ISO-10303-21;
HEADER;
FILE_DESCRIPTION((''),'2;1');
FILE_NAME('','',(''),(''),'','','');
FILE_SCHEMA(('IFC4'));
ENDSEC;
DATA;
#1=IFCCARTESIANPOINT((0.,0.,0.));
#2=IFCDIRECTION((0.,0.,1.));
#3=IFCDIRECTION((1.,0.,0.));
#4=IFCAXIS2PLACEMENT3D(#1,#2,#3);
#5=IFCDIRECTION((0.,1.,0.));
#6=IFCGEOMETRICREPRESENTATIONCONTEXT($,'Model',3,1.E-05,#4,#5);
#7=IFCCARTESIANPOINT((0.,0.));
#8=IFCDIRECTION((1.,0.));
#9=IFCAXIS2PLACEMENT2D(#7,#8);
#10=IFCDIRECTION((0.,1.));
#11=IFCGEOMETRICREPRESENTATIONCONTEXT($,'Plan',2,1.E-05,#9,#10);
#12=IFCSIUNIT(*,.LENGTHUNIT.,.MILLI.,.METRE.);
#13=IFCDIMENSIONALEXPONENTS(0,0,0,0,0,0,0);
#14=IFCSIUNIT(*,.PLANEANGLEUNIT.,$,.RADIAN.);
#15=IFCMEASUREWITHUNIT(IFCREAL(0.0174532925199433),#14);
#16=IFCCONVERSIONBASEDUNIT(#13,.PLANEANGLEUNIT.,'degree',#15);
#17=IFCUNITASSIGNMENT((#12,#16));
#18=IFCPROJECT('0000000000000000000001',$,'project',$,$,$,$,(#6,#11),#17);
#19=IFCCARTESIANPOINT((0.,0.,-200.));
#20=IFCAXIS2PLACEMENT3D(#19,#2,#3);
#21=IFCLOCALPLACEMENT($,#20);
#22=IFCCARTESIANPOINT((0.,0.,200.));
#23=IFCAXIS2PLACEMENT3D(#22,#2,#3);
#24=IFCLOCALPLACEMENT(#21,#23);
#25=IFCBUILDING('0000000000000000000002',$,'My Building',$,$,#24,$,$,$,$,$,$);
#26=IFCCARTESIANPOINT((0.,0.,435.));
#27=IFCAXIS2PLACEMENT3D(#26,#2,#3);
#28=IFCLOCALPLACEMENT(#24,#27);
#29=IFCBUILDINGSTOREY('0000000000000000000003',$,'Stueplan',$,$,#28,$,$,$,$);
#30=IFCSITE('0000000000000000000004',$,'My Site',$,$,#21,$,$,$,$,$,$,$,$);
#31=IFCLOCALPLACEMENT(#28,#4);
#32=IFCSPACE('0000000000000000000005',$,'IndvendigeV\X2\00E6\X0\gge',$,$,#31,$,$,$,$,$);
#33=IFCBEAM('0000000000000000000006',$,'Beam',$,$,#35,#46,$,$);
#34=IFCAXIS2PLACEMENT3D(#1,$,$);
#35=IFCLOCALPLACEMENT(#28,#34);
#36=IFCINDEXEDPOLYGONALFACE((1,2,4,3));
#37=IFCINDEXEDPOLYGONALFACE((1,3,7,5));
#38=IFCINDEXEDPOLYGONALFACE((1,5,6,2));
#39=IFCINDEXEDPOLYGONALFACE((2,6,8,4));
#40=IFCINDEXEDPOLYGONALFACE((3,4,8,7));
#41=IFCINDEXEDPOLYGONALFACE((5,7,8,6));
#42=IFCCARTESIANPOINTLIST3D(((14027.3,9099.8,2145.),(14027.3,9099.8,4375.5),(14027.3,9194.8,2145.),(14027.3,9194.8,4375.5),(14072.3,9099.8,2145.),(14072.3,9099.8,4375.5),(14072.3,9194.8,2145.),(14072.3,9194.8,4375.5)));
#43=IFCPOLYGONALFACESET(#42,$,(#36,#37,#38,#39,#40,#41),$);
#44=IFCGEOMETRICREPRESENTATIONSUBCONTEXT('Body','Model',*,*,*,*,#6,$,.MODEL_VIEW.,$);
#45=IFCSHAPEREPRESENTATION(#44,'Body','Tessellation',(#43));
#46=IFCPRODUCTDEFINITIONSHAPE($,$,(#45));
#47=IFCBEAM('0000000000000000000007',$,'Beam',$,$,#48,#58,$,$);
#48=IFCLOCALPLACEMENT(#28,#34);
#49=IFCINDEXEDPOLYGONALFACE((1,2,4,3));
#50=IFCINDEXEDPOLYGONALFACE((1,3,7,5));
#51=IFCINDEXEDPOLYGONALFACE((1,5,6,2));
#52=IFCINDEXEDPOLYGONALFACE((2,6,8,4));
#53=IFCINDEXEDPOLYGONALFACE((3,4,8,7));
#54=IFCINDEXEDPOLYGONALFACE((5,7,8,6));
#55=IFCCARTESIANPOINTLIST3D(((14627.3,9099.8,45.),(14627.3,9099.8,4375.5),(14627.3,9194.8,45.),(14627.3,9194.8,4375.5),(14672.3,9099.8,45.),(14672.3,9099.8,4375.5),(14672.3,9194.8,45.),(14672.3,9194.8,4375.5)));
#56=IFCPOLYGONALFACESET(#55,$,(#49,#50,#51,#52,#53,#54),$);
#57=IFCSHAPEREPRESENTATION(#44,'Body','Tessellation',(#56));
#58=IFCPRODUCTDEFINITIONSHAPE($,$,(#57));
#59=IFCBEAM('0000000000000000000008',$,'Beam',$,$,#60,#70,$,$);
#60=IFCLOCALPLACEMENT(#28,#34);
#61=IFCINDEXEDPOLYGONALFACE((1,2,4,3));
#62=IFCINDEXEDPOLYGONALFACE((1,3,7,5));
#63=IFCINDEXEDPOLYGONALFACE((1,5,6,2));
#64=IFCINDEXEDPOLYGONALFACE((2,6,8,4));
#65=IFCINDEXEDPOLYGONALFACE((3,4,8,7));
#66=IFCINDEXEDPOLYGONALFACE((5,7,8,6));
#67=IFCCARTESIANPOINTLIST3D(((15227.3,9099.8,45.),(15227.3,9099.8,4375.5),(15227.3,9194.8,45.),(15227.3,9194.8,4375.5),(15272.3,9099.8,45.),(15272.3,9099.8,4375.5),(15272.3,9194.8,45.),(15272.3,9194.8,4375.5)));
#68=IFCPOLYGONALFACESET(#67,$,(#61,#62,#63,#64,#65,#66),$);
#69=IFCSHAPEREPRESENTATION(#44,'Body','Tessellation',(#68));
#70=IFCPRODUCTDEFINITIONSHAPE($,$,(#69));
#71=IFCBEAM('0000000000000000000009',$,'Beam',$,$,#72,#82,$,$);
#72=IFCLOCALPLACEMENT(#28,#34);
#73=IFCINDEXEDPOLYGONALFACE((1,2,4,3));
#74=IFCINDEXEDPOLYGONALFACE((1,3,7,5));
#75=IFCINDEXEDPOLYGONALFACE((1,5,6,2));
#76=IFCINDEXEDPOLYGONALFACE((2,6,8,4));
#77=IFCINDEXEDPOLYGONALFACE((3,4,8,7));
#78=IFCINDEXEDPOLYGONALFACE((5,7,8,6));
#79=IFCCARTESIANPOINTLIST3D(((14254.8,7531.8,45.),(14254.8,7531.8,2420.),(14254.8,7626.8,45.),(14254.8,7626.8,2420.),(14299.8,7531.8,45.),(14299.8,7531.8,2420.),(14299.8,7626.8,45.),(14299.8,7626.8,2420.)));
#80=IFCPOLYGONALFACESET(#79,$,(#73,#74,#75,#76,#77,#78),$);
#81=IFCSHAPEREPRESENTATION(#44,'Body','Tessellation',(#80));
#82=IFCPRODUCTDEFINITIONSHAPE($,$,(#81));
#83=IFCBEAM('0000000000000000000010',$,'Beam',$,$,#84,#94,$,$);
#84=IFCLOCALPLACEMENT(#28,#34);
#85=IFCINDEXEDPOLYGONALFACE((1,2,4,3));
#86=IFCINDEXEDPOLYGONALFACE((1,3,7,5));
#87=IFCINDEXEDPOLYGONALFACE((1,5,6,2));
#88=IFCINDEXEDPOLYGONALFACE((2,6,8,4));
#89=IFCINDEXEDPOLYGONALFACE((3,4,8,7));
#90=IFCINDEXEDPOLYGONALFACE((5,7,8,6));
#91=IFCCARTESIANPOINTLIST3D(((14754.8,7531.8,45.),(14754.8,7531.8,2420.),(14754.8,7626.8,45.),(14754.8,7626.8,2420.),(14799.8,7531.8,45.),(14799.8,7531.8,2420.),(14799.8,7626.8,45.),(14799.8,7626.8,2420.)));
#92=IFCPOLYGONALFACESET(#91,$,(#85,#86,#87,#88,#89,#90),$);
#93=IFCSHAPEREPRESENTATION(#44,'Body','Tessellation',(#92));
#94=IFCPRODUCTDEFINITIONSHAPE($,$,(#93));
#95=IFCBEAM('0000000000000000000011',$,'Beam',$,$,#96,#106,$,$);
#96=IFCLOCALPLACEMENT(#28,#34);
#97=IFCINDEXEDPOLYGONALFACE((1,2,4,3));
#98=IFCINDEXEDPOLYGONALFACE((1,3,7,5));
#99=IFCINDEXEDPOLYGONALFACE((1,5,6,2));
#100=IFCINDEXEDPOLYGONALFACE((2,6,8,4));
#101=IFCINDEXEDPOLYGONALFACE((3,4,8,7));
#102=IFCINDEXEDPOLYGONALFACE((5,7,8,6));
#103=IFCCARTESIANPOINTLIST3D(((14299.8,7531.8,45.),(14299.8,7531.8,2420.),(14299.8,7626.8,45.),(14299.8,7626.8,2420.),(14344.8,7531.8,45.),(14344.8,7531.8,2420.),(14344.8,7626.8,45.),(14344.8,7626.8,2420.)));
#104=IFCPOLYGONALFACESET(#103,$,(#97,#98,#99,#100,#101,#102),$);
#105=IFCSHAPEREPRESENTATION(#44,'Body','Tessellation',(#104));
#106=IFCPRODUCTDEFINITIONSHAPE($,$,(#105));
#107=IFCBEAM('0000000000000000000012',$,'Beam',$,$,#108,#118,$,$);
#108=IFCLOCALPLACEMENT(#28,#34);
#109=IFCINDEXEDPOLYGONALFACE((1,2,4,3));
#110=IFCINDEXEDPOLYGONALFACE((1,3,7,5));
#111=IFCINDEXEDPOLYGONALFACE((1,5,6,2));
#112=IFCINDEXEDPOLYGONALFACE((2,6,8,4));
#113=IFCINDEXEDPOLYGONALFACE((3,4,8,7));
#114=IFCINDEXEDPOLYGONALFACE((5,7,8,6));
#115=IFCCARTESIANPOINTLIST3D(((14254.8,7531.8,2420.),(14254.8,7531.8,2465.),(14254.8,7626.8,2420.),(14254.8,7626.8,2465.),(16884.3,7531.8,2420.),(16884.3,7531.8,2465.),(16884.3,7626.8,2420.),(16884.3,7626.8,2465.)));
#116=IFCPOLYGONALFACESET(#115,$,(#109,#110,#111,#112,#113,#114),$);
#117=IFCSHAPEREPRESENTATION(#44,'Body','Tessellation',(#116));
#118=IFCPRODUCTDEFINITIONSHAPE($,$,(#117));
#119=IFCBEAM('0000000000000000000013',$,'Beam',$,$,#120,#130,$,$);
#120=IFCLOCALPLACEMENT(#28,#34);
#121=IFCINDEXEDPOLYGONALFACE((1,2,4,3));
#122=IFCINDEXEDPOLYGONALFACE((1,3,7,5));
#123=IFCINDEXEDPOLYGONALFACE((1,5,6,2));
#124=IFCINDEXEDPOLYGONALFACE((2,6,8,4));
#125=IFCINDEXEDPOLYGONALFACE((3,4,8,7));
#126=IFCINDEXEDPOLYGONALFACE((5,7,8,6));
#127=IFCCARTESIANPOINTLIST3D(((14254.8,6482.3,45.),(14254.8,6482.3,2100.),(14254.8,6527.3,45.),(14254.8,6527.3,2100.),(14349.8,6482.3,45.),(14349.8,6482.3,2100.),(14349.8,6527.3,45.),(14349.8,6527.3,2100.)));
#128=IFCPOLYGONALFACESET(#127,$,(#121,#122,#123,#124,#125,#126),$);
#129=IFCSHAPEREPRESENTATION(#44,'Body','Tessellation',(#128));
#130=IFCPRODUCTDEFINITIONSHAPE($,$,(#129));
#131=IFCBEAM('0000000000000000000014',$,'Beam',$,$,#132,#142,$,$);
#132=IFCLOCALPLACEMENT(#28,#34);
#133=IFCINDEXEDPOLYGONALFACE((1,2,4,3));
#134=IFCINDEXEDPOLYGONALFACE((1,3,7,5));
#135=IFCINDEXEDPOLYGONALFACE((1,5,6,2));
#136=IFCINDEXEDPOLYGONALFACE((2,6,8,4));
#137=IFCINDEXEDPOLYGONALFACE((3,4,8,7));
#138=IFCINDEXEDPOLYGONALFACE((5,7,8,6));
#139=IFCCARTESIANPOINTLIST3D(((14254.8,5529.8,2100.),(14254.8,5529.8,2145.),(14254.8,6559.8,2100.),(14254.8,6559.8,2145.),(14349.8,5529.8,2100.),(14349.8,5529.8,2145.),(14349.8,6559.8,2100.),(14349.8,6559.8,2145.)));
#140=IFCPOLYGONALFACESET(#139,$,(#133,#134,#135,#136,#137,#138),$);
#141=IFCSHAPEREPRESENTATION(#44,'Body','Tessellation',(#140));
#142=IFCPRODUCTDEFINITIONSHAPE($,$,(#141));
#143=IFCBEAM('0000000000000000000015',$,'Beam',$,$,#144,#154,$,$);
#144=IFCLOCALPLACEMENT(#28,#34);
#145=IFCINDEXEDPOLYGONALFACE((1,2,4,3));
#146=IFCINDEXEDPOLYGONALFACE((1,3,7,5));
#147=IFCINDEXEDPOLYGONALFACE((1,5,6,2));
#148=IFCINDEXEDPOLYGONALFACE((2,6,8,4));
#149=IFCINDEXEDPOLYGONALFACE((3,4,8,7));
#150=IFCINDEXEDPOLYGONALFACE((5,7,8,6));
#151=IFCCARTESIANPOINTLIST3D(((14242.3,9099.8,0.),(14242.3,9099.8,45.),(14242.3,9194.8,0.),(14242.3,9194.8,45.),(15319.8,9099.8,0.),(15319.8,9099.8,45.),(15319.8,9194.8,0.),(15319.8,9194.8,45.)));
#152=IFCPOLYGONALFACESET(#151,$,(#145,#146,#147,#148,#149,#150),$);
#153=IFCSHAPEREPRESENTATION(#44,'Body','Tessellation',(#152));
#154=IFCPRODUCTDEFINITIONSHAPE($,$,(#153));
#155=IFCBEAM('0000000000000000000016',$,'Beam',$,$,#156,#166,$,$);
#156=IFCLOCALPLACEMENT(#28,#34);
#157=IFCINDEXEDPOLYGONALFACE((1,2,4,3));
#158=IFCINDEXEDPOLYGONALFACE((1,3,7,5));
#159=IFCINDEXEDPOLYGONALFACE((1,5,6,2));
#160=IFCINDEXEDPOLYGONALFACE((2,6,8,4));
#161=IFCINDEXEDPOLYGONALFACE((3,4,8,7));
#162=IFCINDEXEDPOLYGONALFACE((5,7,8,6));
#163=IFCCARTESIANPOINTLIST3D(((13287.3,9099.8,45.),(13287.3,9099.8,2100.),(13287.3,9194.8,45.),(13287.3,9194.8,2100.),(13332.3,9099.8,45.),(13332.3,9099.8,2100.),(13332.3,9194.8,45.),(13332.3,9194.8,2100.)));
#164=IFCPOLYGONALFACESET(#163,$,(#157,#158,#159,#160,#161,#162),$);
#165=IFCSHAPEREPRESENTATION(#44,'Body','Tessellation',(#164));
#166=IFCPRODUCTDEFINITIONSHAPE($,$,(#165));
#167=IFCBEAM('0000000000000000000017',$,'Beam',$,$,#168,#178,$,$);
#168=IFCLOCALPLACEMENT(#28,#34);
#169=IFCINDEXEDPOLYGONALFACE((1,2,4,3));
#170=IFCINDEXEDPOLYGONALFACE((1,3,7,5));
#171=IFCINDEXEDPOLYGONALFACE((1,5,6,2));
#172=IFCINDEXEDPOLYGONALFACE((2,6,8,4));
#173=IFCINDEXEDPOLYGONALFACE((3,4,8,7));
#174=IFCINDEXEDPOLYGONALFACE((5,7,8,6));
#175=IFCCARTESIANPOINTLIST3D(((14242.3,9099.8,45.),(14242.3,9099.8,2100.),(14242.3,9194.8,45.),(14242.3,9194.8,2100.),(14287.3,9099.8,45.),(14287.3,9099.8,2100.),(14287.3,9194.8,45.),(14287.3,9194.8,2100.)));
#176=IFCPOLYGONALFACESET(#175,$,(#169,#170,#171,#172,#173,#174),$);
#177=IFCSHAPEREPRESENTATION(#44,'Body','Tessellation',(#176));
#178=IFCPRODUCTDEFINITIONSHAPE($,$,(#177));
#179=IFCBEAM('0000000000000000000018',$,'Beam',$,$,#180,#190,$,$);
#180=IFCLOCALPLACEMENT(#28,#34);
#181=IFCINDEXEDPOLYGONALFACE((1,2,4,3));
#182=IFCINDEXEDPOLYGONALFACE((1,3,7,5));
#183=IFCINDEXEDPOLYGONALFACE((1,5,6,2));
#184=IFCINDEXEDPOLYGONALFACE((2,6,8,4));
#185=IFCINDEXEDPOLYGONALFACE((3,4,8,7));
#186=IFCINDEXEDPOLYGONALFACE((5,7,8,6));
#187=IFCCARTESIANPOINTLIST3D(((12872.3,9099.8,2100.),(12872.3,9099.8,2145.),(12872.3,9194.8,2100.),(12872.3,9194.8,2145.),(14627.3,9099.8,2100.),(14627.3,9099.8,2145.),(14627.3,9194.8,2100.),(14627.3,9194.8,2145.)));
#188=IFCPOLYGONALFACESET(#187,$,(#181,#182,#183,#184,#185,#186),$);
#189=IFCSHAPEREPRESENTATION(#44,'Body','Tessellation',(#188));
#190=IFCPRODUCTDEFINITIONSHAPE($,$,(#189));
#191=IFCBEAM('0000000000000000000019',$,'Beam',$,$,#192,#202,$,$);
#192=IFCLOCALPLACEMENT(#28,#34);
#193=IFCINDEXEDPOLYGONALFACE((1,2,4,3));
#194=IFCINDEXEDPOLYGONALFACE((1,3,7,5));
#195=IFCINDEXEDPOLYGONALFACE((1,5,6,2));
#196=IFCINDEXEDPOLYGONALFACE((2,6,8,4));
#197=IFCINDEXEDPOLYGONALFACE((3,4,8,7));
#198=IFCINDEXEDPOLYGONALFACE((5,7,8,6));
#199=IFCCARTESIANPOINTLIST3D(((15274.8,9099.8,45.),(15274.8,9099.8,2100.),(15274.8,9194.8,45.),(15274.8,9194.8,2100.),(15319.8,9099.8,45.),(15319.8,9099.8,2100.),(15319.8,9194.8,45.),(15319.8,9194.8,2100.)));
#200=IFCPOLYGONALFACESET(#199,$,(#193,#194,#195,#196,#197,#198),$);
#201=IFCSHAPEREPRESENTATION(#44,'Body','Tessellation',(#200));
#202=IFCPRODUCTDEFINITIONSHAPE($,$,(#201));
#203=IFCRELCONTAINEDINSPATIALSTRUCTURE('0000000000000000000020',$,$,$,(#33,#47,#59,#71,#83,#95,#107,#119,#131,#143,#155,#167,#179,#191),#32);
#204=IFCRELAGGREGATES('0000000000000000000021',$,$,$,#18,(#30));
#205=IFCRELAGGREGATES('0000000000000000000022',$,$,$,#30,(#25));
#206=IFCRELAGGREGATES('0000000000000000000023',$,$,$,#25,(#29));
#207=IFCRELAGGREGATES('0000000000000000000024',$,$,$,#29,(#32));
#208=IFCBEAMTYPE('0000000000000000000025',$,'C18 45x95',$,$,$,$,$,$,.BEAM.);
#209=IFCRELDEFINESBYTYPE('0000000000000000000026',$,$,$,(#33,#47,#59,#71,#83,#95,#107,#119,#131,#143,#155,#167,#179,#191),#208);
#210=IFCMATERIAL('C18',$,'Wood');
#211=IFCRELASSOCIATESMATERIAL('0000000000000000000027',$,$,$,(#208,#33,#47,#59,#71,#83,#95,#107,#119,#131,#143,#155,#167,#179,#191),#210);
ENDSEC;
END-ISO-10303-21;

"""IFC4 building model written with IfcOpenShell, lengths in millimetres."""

from ifc_helpers import new_model, entity, si_unit, converted_unit, direction, frame, origin_with_axes, origin_2d_with_axis, place, context, subcontext, project, spatial, rectangle, extrude, material, material_profile, profile_set, profile_usage, type_object, element, save


model = new_model("IFC4")

# Units and contexts
model_context = context("Model", 3, precision=1e-05, world=origin_with_axes(), true_north=direction((0.0, 1.0, 0.0)))
plan_context = context("Plan", 2, precision=1e-05, world=origin_2d_with_axis(), true_north=direction((0.0, 1.0)))
body_context_1 = subcontext(model_context, "Body", "Model", "MODEL_VIEW")
ifc_project = project(units=[si_unit("LENGTHUNIT", "METRE", prefix="MILLI"), converted_unit("PLANEANGLEUNIT", "degree", entity("IfcReal", 0.0174532925199433), si_unit("PLANEANGLEUNIT", "RADIAN"), dimensions=[0, 0, 0, 0, 0, 0, 0])], contexts=[model_context, plan_context])

# Site, building, storey
site_placement = place(None, frame((0.0, 0.0, -200.0), z_axis=(0.0, 0.0, 1.0), x_axis=(1.0, 0.0, 0.0)))
site = spatial("IfcSite", under=ifc_project, at=site_placement, Name="My Site")
building_placement = place(site_placement, frame((0.0, 0.0, 200.0), z_axis=(0.0, 0.0, 1.0), x_axis=(1.0, 0.0, 0.0)))
building = spatial("IfcBuilding", under=site, at=building_placement, Name="My Building")
storey_placement = place(building_placement, frame((0.0, 0.0, 435.0), z_axis=(0.0, 0.0, 1.0), x_axis=(1.0, 0.0, 0.0)))
storey = spatial("IfcBuildingStorey", under=building, at=storey_placement, Name="Stueplan")

# Shared definitions
ifc_material = material(Name="C18", Category="Wood")

# Shared definitions
space_1_placement = place(storey_placement, frame((0.0, 0.0, 0.0), z_axis=(0.0, 0.0, 1.0), x_axis=(1.0, 0.0, 0.0)))
space_1 = spatial("IfcSpace", under=storey, at=space_1_placement, Name="IndvendigeVægge")

# Beams
ifc_material_profile_1 = material_profile(ifc_material, rectangle(XDim=45.0, YDim=95.0))
ifc_profile_set_1 = profile_set([ifc_material_profile_1], Name="woodStructural")
beam_type_1 = type_object("IfcBeamType", Name="C18 45x95", PredefinedType="BEAM", material=ifc_profile_set_1)
ifc_profile_usage_1 = profile_usage(ifc_profile_set_1)
beam_1_placement = place(space_1_placement, frame((14049.8, 9147.3, 2145.0), z_axis=(0.0, 0.0, 1.0), x_axis=(-1.0, 0.0, 0.0)))
element("IfcBeam", 1, at=beam_1_placement, inside=space_1, type_object=beam_type_1, material=ifc_profile_usage_1, Name="Beam", context=body_context_1, shape_type="SweptSolid", body=[
    extrude(rectangle(XDim=45.0, YDim=95.0), origin_with_axes(), (0.0, 0.0, 1.0), 2230.5),
])
ifc_profile_usage_2 = profile_usage(ifc_profile_set_1)
beam_2_placement = place(space_1_placement, frame((14649.8, 9147.3, 45.0), z_axis=(0.0, 0.0, 1.0), x_axis=(-1.0, 0.0, 0.0)))
element("IfcBeam", 2, at=beam_2_placement, inside=space_1, type_object=beam_type_1, material=ifc_profile_usage_2, Name="Beam", context=body_context_1, shape_type="SweptSolid", body=[
    extrude(rectangle(XDim=45.0, YDim=95.0), origin_with_axes(), (0.0, 0.0, 1.0), 4330.5),
])
ifc_profile_usage_3 = profile_usage(ifc_profile_set_1)
beam_3_placement = place(space_1_placement, frame((15249.8, 9147.3, 45.0), z_axis=(0.0, 0.0, 1.0), x_axis=(-1.0, 0.0, 0.0)))
element("IfcBeam", 3, at=beam_3_placement, inside=space_1, type_object=beam_type_1, material=ifc_profile_usage_3, Name="Beam", context=body_context_1, shape_type="SweptSolid", body=[
    extrude(rectangle(XDim=45.0, YDim=95.0), origin_with_axes(), (0.0, 0.0, 1.0), 4330.5),
])
ifc_profile_usage_4 = profile_usage(ifc_profile_set_1)
beam_4_placement = place(space_1_placement, frame((14277.3, 7579.3, 45.0), z_axis=(0.0, 0.0, 1.0), x_axis=(1.0, 0.0, 0.0)))
element("IfcBeam", 4, at=beam_4_placement, inside=space_1, type_object=beam_type_1, material=ifc_profile_usage_4, Name="Beam", context=body_context_1, shape_type="SweptSolid", body=[
    extrude(rectangle(XDim=45.0, YDim=95.0), origin_with_axes(), (0.0, 0.0, 1.0), 2375.0),
])
ifc_profile_usage_5 = profile_usage(ifc_profile_set_1)
beam_5_placement = place(space_1_placement, frame((14777.3, 7579.3, 45.0), z_axis=(0.0, 0.0, 1.0), x_axis=(1.0, 0.0, 0.0)))
element("IfcBeam", 5, at=beam_5_placement, inside=space_1, type_object=beam_type_1, material=ifc_profile_usage_5, Name="Beam", context=body_context_1, shape_type="SweptSolid", body=[
    extrude(rectangle(XDim=45.0, YDim=95.0), origin_with_axes(), (0.0, 0.0, 1.0), 2375.0),
])
ifc_profile_usage_6 = profile_usage(ifc_profile_set_1)
beam_6_placement = place(space_1_placement, frame((14322.3, 7579.3, 45.0), z_axis=(0.0, 0.0, 1.0), x_axis=(1.0, 0.0, 0.0)))
element("IfcBeam", 6, at=beam_6_placement, inside=space_1, type_object=beam_type_1, material=ifc_profile_usage_6, Name="Beam", context=body_context_1, shape_type="SweptSolid", body=[
    extrude(rectangle(XDim=45.0, YDim=95.0), origin_with_axes(), (0.0, 0.0, 1.0), 2375.0),
])
ifc_profile_usage_7 = profile_usage(ifc_profile_set_1, cardinal=5)
beam_7_placement = place(space_1_placement, frame((14254.8, 7579.3, 2442.5), z_axis=(1.0, 0.0, 0.0), x_axis=(0.0, 0.0, 1.0)))
element("IfcBeam", 7, at=beam_7_placement, inside=space_1, type_object=beam_type_1, material=ifc_profile_usage_7, Name="Beam", context=body_context_1, shape_type="SweptSolid", body=[
    extrude(rectangle(XDim=45.0, YDim=95.0), origin_with_axes(), (0.0, 0.0, 1.0), 2629.5),
])
ifc_profile_usage_8 = profile_usage(ifc_profile_set_1)
beam_8_placement = place(space_1_placement, frame((14302.3, 6504.8, 45.0), z_axis=(0.0, 0.0, 1.0), x_axis=(0.0, -1.0, 0.0)))
element("IfcBeam", 8, at=beam_8_placement, inside=space_1, type_object=beam_type_1, material=ifc_profile_usage_8, Name="Beam", context=body_context_1, shape_type="SweptSolid", body=[
    extrude(rectangle(XDim=45.0, YDim=95.0), origin_with_axes(), (0.0, 0.0, 1.0), 2055.0),
])
ifc_profile_usage_9 = profile_usage(ifc_profile_set_1, cardinal=5)
beam_9_placement = place(space_1_placement, frame((14302.3, 6559.8, 2122.5), z_axis=(0.0, -1.0, 0.0), x_axis=(0.0, 0.0, 1.0)))
element("IfcBeam", 9, at=beam_9_placement, inside=space_1, type_object=beam_type_1, material=ifc_profile_usage_9, Name="Beam", context=body_context_1, shape_type="SweptSolid", body=[
    extrude(rectangle(XDim=45.0, YDim=95.0), origin_with_axes(), (0.0, 0.0, 1.0), 1030.0),
])
ifc_profile_usage_10 = profile_usage(ifc_profile_set_1, cardinal=5)
beam_10_placement = place(space_1_placement, frame((14242.3, 9147.3, 22.5), z_axis=(1.0, 0.0, 0.0), x_axis=(0.0, 0.0, 1.0)))
element("IfcBeam", 10, at=beam_10_placement, inside=space_1, type_object=beam_type_1, material=ifc_profile_usage_10, Name="Beam", context=body_context_1, shape_type="SweptSolid", body=[
    extrude(rectangle(XDim=45.0, YDim=95.0), origin_with_axes(), (0.0, 0.0, 1.0), 1077.5),
])
ifc_profile_usage_11 = profile_usage(ifc_profile_set_1)
beam_11_placement = place(space_1_placement, frame((13309.8, 9147.3, 45.0), z_axis=(0.0, 0.0, 1.0), x_axis=(1.0, 0.0, 0.0)))
element("IfcBeam", 11, at=beam_11_placement, inside=space_1, type_object=beam_type_1, material=ifc_profile_usage_11, Name="Beam", context=body_context_1, shape_type="SweptSolid", body=[
    extrude(rectangle(XDim=45.0, YDim=95.0), origin_with_axes(), (0.0, 0.0, 1.0), 2055.0),
])
ifc_profile_usage_12 = profile_usage(ifc_profile_set_1)
beam_12_placement = place(space_1_placement, frame((14264.8, 9147.3, 45.0), z_axis=(0.0, 0.0, 1.0), x_axis=(1.0, 0.0, 0.0)))
element("IfcBeam", 12, at=beam_12_placement, inside=space_1, type_object=beam_type_1, material=ifc_profile_usage_12, Name="Beam", context=body_context_1, shape_type="SweptSolid", body=[
    extrude(rectangle(XDim=45.0, YDim=95.0), origin_with_axes(), (0.0, 0.0, 1.0), 2055.0),
])
ifc_profile_usage_13 = profile_usage(ifc_profile_set_1, cardinal=5)
beam_13_placement = place(space_1_placement, frame((12872.3, 9147.3, 2122.5), z_axis=(1.0, 0.0, 0.0), x_axis=(0.0, 0.0, 1.0)))
element("IfcBeam", 13, at=beam_13_placement, inside=space_1, type_object=beam_type_1, material=ifc_profile_usage_13, Name="Beam", context=body_context_1, shape_type="SweptSolid", body=[
    extrude(rectangle(XDim=45.0, YDim=95.0), origin_with_axes(), (0.0, 0.0, 1.0), 1755.0),
])
ifc_profile_usage_14 = profile_usage(ifc_profile_set_1)
beam_14_placement = place(space_1_placement, frame((15297.3, 9147.3, 45.0), z_axis=(0.0, 0.0, 1.0), x_axis=(1.0, 0.0, 0.0)))
element("IfcBeam", 14, at=beam_14_placement, inside=space_1, type_object=beam_type_1, material=ifc_profile_usage_14, Name="Beam", context=body_context_1, shape_type="SweptSolid", body=[
    extrude(rectangle(XDim=45.0, YDim=95.0), origin_with_axes(), (0.0, 0.0, 1.0), 2055.0),
])

save(model, "model.ifc")
